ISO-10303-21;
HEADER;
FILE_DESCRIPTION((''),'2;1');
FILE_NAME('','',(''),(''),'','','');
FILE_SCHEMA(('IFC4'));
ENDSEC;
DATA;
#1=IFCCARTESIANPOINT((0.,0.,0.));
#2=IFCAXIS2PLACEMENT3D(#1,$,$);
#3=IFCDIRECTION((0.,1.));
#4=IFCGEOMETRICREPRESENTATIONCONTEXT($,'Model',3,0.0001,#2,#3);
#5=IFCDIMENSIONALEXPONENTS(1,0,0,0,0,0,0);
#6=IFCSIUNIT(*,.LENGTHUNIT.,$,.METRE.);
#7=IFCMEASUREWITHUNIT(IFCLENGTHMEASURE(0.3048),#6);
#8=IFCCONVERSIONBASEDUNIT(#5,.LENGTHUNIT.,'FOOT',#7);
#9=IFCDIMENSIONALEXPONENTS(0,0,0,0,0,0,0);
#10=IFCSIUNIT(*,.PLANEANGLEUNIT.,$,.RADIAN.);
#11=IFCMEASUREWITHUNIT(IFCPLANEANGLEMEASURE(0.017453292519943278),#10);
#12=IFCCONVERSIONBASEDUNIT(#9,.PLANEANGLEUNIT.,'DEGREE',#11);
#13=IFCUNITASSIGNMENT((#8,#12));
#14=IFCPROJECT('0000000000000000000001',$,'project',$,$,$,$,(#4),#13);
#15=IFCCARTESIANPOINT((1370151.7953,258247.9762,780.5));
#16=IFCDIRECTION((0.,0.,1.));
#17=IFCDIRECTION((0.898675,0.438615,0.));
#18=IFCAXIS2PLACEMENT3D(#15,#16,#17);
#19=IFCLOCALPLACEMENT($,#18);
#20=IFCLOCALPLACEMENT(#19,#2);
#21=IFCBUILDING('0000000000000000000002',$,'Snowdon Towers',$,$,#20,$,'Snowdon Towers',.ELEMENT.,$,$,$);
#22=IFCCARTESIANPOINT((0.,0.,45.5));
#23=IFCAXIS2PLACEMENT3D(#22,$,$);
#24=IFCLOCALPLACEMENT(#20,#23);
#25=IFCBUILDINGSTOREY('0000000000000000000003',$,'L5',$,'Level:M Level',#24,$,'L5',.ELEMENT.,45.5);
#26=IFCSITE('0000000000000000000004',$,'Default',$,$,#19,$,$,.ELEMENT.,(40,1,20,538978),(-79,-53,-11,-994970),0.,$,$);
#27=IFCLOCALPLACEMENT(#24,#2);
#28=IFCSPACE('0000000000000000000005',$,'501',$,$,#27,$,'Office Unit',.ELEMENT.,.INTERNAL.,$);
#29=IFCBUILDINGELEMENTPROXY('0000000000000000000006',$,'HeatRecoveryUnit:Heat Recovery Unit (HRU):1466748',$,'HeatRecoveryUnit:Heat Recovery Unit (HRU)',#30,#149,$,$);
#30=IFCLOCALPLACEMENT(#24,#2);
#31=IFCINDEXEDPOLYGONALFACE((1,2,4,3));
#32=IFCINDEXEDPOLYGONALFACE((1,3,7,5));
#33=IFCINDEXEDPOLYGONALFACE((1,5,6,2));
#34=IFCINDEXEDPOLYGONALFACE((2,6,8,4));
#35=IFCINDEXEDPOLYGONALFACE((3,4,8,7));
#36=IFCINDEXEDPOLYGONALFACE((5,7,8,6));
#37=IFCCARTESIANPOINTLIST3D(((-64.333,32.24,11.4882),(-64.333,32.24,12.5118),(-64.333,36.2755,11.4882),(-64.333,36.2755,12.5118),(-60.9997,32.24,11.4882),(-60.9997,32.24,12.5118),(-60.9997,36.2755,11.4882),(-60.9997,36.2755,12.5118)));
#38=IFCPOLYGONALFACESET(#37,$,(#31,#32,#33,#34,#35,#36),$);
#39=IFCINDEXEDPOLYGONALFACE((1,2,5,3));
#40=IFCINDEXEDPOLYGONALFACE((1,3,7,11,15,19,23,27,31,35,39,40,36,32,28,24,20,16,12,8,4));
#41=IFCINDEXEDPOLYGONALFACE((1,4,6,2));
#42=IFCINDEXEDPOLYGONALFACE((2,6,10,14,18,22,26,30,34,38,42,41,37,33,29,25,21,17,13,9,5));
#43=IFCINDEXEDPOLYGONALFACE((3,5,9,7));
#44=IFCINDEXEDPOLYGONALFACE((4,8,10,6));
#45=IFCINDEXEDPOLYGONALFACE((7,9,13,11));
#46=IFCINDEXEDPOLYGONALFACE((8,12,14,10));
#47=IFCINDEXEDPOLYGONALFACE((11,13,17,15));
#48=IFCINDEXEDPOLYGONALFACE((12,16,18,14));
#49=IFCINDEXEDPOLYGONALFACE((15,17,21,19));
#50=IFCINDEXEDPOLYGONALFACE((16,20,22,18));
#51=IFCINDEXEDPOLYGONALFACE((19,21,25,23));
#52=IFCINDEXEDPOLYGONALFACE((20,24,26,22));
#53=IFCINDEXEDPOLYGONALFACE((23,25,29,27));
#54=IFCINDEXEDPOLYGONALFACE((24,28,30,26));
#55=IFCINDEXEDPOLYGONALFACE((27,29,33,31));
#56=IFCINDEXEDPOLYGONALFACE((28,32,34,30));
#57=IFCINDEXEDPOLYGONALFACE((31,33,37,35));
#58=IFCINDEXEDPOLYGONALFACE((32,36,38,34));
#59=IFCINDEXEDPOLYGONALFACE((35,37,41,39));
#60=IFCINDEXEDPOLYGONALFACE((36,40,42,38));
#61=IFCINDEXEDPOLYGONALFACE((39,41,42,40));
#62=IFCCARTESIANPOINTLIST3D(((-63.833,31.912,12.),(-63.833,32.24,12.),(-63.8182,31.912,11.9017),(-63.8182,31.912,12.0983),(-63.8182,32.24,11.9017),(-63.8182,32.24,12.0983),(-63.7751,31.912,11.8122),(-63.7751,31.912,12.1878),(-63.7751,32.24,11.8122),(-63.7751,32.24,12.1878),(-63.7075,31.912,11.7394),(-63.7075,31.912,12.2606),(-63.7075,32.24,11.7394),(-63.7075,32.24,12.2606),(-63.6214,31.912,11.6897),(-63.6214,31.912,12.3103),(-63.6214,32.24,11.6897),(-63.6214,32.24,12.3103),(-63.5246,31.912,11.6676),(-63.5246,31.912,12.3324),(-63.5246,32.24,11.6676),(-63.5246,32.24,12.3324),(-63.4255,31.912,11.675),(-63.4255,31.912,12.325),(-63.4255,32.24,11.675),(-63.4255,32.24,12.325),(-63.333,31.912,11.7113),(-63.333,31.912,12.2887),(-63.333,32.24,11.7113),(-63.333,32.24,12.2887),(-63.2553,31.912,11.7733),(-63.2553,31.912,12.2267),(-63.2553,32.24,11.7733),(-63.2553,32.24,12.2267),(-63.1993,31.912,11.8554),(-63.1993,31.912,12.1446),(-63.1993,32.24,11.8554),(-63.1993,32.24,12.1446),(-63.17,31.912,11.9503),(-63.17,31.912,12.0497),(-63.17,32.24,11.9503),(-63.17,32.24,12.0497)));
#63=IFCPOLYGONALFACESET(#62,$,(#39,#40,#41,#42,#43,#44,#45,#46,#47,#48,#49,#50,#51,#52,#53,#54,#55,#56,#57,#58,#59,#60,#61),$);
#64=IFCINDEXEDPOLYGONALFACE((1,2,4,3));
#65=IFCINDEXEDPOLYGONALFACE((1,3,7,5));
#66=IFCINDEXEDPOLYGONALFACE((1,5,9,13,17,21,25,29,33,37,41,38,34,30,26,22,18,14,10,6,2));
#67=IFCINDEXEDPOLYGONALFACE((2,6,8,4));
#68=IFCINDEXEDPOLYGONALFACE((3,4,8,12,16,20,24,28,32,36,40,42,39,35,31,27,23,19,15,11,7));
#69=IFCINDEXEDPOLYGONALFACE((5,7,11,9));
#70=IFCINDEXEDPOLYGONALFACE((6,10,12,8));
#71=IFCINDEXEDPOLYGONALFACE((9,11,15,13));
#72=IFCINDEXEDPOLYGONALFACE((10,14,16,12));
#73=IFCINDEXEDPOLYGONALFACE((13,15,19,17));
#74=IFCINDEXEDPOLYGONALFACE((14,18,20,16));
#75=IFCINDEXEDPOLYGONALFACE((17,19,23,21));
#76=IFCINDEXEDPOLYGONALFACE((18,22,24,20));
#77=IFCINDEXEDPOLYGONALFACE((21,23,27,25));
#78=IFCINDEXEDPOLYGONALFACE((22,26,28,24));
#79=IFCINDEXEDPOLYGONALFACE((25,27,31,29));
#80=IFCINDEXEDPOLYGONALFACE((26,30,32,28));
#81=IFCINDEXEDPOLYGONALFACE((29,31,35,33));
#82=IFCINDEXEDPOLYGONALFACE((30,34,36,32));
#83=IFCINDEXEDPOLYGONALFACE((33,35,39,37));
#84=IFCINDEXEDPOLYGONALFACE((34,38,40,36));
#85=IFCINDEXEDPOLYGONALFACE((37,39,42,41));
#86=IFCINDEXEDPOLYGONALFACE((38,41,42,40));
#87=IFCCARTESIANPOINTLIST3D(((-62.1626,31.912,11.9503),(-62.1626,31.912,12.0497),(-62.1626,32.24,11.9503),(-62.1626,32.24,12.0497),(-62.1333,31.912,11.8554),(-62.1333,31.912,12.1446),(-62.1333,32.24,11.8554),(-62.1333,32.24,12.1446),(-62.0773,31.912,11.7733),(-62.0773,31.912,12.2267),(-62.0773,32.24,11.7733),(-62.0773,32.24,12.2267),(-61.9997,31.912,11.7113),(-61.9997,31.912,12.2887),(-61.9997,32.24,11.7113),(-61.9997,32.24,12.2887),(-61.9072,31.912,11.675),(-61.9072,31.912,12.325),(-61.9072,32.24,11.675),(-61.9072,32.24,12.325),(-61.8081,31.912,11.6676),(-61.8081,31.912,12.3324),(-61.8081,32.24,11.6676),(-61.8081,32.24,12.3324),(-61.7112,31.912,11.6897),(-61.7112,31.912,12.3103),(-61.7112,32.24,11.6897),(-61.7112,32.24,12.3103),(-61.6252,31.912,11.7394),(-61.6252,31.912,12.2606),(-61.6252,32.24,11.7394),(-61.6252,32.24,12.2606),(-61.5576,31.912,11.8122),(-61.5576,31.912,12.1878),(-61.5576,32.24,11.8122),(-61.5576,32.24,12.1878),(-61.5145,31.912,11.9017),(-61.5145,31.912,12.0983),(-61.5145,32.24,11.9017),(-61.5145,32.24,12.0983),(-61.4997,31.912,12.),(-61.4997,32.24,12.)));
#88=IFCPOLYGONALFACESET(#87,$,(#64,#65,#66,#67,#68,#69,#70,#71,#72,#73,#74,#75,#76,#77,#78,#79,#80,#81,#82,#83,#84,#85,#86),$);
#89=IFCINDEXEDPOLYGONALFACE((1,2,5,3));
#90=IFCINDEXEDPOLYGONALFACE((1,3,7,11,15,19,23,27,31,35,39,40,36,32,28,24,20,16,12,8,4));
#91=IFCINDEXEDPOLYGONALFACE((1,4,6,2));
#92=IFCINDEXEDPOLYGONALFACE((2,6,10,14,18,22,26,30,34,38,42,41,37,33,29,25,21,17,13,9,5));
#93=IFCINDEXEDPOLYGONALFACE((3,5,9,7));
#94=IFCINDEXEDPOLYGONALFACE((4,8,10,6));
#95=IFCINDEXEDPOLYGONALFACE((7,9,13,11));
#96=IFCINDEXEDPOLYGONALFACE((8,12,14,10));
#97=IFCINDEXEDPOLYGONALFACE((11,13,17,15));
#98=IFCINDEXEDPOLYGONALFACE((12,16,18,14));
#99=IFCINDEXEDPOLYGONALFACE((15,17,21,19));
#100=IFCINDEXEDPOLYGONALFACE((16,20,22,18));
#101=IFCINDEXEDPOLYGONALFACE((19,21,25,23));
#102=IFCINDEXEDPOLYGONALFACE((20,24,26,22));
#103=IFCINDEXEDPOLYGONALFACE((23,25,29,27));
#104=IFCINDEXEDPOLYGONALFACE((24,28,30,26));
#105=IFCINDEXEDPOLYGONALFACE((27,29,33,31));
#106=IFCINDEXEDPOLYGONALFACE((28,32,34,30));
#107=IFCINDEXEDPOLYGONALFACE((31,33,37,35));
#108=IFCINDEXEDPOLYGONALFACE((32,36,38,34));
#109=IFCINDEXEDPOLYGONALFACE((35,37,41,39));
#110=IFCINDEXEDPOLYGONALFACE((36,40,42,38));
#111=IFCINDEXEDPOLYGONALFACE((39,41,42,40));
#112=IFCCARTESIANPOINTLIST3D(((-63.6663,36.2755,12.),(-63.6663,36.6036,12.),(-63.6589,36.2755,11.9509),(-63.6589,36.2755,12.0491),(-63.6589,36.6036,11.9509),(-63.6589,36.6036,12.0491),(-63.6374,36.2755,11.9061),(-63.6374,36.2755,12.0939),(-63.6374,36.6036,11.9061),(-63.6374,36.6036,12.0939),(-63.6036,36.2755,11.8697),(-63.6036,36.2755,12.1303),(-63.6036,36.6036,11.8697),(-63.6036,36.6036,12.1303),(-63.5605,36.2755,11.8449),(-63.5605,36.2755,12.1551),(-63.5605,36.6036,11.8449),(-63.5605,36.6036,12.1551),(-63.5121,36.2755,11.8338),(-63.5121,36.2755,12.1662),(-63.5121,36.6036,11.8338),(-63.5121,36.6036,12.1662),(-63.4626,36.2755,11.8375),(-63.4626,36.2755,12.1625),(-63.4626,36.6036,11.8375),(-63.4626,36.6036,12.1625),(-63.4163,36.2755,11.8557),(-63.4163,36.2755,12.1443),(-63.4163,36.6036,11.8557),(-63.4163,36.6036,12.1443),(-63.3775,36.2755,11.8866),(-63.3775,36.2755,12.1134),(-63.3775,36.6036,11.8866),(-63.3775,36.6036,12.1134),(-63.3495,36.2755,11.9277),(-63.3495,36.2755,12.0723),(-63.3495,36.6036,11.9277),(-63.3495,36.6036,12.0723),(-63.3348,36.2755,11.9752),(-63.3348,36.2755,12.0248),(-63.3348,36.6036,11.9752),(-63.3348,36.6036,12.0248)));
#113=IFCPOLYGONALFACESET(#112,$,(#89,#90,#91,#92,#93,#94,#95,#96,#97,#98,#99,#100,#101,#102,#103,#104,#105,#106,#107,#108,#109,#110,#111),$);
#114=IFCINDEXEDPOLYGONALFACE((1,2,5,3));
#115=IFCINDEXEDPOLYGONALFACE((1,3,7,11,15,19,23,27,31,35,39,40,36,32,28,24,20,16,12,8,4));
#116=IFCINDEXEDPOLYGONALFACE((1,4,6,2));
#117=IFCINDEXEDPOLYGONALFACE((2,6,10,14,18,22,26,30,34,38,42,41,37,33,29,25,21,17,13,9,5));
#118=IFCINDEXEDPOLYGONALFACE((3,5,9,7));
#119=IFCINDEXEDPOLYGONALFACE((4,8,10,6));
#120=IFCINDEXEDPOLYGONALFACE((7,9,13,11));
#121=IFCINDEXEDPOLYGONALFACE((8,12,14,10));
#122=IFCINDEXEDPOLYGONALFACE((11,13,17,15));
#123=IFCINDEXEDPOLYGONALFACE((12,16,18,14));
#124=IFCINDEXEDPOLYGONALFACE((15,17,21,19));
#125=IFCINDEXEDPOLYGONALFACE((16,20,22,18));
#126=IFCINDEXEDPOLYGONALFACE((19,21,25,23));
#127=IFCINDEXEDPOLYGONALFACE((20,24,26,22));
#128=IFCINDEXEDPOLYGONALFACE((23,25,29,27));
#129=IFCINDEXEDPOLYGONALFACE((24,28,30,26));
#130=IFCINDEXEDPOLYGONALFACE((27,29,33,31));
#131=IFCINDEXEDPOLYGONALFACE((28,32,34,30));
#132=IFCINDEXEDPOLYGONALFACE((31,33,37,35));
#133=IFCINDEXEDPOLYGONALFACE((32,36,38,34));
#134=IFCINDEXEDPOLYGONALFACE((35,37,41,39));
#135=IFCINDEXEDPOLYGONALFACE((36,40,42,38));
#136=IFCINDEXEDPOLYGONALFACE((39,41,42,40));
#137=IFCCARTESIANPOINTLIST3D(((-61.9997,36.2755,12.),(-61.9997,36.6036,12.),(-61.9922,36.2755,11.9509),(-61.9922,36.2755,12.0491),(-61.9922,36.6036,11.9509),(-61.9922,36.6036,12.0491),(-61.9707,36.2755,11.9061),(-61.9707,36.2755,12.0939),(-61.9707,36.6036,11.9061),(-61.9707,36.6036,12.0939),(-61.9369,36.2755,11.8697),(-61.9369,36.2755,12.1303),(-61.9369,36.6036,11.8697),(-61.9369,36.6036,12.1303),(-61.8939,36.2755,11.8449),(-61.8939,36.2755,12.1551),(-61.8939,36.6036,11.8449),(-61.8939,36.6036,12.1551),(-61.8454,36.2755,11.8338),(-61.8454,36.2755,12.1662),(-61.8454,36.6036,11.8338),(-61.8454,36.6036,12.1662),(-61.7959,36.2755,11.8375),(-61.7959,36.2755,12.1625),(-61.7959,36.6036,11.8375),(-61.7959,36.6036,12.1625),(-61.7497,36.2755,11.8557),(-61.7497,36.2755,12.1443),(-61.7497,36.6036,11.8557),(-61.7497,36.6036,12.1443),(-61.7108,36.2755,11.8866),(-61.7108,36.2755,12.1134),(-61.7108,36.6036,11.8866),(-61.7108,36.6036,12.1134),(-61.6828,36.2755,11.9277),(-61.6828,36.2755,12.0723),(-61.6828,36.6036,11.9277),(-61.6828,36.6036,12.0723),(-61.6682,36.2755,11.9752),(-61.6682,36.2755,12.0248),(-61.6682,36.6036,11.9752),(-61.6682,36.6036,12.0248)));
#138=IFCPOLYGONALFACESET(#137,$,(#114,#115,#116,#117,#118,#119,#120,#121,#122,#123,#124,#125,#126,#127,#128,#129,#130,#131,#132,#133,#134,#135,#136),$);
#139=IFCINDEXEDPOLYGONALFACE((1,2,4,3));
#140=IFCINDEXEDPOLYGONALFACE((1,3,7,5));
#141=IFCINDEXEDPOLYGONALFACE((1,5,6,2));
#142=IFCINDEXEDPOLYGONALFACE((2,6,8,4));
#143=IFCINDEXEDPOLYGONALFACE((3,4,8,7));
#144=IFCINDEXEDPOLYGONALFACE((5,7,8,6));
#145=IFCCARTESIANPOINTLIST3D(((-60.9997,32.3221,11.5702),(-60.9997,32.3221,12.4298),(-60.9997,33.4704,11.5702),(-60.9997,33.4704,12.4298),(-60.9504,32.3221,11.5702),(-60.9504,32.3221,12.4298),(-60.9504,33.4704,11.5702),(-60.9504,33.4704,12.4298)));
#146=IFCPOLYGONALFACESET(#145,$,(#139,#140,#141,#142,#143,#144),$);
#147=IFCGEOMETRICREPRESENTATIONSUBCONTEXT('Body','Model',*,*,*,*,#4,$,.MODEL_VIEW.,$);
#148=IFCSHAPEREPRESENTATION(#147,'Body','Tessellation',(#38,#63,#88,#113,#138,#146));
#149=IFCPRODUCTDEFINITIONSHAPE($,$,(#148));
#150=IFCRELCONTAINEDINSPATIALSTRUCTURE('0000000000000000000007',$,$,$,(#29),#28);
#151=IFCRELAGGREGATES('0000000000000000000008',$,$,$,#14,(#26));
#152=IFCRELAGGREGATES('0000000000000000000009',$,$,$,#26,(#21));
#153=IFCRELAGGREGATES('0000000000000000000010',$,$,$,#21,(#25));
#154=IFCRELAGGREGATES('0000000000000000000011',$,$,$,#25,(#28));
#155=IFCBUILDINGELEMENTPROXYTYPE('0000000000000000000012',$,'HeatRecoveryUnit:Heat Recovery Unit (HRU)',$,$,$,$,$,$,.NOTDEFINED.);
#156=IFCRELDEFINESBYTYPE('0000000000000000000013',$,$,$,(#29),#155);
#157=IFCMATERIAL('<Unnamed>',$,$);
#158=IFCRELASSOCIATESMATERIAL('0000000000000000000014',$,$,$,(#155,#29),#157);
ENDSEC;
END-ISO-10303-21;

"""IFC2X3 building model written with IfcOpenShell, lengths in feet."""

from ifc_helpers import new_model, entity, si_unit, converted_unit, direction, frame, frame_2d, origin, origin_2d_with_axis, place, context, subcontext, project, spatial, rectangle, circle, extrude, source, transform, mapped, material, type_object, type_shapes, element, save


model = new_model("IFC2X3")

# Units and contexts
model_context = context("Model", 3, precision=0.0001, world=origin(), true_north=direction((0.0, 1.0)))
body_context = subcontext(model_context, "Body", "Model", "MODEL_VIEW")
ifc_project = project(units=[converted_unit("LENGTHUNIT", "FOOT", entity("IfcLengthMeasure", 0.3048), si_unit("LENGTHUNIT", "METRE"), dimensions=[1, 0, 0, 0, 0, 0, 0]), converted_unit("PLANEANGLEUNIT", "DEGREE", entity("IfcPlaneAngleMeasure", 0.017453292519943278), si_unit("PLANEANGLEUNIT", "RADIAN"), dimensions=[0, 0, 0, 0, 0, 0, 0])], contexts=[model_context])

# Site, building, storey
site_placement = place(None, frame((1370151.7953, 258247.9762, 780.5), z_axis=(0.0, 0.0, 1.0), x_axis=(0.898675, 0.438615, 0.0)))
site = spatial("IfcSite", under=ifc_project, at=site_placement, Name="Default", CompositionType="ELEMENT", RefLatitude=(40, 1, 20, 538978), RefLongitude=(-79, -53, -11, -994970), RefElevation=0.0)
building_placement = place(site_placement, origin())
building = spatial("IfcBuilding", under=site, at=building_placement, Name="Snowdon Towers", LongName="Snowdon Towers", CompositionType="ELEMENT")
storey_placement = place(building_placement, frame((0.0, 0.0, 45.5)))
storey = spatial("IfcBuildingStorey", under=building, at=storey_placement, Name="L5", ObjectType="Level:M Level", LongName="L5", CompositionType="ELEMENT", Elevation=45.5)

# Shared definitions
ifc_material = material(Name="<Unnamed>")

# Shared definitions
space_placement = place(storey_placement, origin())
space = spatial("IfcSpace", under=storey, at=space_placement, Name="501", LongName="Office Unit", CompositionType="ELEMENT", InteriorOrExteriorSpace="INTERNAL")

# Building element proxy
building_element_proxy_type = type_object("IfcBuildingElementProxyType", Name="HeatRecoveryUnit:Heat Recovery Unit (HRU)", PredefinedType="NOTDEFINED", material=ifc_material)
shared_shape_1 = source(origin(), body_context, "Body", "SweptSolid", [
    extrude(rectangle(XDim=3.3333, YDim=4.0354, at=origin_2d_with_axis()), frame((0.0, 0.0, 0.0), z_axis=(0.0, 0.0, 1.0), x_axis=(-1.0, 0.0, 0.0)), (0.0, 0.0, 1.0), 1.0236),
    extrude(circle(Radius=0.3333, at=frame_2d((0.0, 0.0), x_axis=(1.0, 0.0))), frame((-0.8333, -2.3458, 0.5118), z_axis=(0.0, 1.0, 0.0), x_axis=(-1.0, 0.0, 0.0)), (0.0, 0.0, 1.0), 0.3281),
    extrude(circle(Radius=0.3333, at=frame_2d((0.0, 0.0), x_axis=(1.0, 0.0))), frame((0.8333, -2.3458, 0.5118), z_axis=(0.0, 1.0, 0.0), x_axis=(1.0, 0.0, 0.0)), (0.0, 0.0, 1.0), 0.3281),
    extrude(circle(Radius=0.1667, at=frame_2d((0.0, 0.0), x_axis=(1.0, 0.0))), frame((-0.8333, 2.0177, 0.5118), z_axis=(0.0, 1.0, 0.0), x_axis=(-1.0, 0.0, 0.0)), (0.0, 0.0, 1.0), 0.3281),
    extrude(circle(Radius=0.1667, at=frame_2d((0.0, 0.0), x_axis=(1.0, 0.0))), frame((0.8333, 2.0177, 0.5118), z_axis=(0.0, 1.0, 0.0), x_axis=(-1.0, 0.0, 0.0)), (0.0, 0.0, 1.0), 0.3281),
    extrude(rectangle(XDim=0.0492, YDim=1.1483, at=origin_2d_with_axis()), frame((1.6913, -1.3615, 0.082), z_axis=(0.0, 0.0, 1.0), x_axis=(-1.0, 0.0, 0.0)), (0.0, 0.0, 1.0), 0.8596),
])
type_shapes(building_element_proxy_type, [shared_shape_1])
for number, where, name in (
    (1, (-62.6663, 34.2578, 11.4882), "HeatRecoveryUnit:Heat Recovery Unit (HRU):1466748"),
):
    element("IfcBuildingElementProxy", number, at=place(space_placement, frame(where)), inside=space, type_object=building_element_proxy_type, material=ifc_material, Name=name, ObjectType="HeatRecoveryUnit:Heat Recovery Unit (HRU)", context=body_context, shape_type="MappedRepresentation", body=[
        mapped(shared_shape_1, transform((0.0, 0.0, 0.0), scale=1.0)),
    ])

save(model, "model.ifc")
